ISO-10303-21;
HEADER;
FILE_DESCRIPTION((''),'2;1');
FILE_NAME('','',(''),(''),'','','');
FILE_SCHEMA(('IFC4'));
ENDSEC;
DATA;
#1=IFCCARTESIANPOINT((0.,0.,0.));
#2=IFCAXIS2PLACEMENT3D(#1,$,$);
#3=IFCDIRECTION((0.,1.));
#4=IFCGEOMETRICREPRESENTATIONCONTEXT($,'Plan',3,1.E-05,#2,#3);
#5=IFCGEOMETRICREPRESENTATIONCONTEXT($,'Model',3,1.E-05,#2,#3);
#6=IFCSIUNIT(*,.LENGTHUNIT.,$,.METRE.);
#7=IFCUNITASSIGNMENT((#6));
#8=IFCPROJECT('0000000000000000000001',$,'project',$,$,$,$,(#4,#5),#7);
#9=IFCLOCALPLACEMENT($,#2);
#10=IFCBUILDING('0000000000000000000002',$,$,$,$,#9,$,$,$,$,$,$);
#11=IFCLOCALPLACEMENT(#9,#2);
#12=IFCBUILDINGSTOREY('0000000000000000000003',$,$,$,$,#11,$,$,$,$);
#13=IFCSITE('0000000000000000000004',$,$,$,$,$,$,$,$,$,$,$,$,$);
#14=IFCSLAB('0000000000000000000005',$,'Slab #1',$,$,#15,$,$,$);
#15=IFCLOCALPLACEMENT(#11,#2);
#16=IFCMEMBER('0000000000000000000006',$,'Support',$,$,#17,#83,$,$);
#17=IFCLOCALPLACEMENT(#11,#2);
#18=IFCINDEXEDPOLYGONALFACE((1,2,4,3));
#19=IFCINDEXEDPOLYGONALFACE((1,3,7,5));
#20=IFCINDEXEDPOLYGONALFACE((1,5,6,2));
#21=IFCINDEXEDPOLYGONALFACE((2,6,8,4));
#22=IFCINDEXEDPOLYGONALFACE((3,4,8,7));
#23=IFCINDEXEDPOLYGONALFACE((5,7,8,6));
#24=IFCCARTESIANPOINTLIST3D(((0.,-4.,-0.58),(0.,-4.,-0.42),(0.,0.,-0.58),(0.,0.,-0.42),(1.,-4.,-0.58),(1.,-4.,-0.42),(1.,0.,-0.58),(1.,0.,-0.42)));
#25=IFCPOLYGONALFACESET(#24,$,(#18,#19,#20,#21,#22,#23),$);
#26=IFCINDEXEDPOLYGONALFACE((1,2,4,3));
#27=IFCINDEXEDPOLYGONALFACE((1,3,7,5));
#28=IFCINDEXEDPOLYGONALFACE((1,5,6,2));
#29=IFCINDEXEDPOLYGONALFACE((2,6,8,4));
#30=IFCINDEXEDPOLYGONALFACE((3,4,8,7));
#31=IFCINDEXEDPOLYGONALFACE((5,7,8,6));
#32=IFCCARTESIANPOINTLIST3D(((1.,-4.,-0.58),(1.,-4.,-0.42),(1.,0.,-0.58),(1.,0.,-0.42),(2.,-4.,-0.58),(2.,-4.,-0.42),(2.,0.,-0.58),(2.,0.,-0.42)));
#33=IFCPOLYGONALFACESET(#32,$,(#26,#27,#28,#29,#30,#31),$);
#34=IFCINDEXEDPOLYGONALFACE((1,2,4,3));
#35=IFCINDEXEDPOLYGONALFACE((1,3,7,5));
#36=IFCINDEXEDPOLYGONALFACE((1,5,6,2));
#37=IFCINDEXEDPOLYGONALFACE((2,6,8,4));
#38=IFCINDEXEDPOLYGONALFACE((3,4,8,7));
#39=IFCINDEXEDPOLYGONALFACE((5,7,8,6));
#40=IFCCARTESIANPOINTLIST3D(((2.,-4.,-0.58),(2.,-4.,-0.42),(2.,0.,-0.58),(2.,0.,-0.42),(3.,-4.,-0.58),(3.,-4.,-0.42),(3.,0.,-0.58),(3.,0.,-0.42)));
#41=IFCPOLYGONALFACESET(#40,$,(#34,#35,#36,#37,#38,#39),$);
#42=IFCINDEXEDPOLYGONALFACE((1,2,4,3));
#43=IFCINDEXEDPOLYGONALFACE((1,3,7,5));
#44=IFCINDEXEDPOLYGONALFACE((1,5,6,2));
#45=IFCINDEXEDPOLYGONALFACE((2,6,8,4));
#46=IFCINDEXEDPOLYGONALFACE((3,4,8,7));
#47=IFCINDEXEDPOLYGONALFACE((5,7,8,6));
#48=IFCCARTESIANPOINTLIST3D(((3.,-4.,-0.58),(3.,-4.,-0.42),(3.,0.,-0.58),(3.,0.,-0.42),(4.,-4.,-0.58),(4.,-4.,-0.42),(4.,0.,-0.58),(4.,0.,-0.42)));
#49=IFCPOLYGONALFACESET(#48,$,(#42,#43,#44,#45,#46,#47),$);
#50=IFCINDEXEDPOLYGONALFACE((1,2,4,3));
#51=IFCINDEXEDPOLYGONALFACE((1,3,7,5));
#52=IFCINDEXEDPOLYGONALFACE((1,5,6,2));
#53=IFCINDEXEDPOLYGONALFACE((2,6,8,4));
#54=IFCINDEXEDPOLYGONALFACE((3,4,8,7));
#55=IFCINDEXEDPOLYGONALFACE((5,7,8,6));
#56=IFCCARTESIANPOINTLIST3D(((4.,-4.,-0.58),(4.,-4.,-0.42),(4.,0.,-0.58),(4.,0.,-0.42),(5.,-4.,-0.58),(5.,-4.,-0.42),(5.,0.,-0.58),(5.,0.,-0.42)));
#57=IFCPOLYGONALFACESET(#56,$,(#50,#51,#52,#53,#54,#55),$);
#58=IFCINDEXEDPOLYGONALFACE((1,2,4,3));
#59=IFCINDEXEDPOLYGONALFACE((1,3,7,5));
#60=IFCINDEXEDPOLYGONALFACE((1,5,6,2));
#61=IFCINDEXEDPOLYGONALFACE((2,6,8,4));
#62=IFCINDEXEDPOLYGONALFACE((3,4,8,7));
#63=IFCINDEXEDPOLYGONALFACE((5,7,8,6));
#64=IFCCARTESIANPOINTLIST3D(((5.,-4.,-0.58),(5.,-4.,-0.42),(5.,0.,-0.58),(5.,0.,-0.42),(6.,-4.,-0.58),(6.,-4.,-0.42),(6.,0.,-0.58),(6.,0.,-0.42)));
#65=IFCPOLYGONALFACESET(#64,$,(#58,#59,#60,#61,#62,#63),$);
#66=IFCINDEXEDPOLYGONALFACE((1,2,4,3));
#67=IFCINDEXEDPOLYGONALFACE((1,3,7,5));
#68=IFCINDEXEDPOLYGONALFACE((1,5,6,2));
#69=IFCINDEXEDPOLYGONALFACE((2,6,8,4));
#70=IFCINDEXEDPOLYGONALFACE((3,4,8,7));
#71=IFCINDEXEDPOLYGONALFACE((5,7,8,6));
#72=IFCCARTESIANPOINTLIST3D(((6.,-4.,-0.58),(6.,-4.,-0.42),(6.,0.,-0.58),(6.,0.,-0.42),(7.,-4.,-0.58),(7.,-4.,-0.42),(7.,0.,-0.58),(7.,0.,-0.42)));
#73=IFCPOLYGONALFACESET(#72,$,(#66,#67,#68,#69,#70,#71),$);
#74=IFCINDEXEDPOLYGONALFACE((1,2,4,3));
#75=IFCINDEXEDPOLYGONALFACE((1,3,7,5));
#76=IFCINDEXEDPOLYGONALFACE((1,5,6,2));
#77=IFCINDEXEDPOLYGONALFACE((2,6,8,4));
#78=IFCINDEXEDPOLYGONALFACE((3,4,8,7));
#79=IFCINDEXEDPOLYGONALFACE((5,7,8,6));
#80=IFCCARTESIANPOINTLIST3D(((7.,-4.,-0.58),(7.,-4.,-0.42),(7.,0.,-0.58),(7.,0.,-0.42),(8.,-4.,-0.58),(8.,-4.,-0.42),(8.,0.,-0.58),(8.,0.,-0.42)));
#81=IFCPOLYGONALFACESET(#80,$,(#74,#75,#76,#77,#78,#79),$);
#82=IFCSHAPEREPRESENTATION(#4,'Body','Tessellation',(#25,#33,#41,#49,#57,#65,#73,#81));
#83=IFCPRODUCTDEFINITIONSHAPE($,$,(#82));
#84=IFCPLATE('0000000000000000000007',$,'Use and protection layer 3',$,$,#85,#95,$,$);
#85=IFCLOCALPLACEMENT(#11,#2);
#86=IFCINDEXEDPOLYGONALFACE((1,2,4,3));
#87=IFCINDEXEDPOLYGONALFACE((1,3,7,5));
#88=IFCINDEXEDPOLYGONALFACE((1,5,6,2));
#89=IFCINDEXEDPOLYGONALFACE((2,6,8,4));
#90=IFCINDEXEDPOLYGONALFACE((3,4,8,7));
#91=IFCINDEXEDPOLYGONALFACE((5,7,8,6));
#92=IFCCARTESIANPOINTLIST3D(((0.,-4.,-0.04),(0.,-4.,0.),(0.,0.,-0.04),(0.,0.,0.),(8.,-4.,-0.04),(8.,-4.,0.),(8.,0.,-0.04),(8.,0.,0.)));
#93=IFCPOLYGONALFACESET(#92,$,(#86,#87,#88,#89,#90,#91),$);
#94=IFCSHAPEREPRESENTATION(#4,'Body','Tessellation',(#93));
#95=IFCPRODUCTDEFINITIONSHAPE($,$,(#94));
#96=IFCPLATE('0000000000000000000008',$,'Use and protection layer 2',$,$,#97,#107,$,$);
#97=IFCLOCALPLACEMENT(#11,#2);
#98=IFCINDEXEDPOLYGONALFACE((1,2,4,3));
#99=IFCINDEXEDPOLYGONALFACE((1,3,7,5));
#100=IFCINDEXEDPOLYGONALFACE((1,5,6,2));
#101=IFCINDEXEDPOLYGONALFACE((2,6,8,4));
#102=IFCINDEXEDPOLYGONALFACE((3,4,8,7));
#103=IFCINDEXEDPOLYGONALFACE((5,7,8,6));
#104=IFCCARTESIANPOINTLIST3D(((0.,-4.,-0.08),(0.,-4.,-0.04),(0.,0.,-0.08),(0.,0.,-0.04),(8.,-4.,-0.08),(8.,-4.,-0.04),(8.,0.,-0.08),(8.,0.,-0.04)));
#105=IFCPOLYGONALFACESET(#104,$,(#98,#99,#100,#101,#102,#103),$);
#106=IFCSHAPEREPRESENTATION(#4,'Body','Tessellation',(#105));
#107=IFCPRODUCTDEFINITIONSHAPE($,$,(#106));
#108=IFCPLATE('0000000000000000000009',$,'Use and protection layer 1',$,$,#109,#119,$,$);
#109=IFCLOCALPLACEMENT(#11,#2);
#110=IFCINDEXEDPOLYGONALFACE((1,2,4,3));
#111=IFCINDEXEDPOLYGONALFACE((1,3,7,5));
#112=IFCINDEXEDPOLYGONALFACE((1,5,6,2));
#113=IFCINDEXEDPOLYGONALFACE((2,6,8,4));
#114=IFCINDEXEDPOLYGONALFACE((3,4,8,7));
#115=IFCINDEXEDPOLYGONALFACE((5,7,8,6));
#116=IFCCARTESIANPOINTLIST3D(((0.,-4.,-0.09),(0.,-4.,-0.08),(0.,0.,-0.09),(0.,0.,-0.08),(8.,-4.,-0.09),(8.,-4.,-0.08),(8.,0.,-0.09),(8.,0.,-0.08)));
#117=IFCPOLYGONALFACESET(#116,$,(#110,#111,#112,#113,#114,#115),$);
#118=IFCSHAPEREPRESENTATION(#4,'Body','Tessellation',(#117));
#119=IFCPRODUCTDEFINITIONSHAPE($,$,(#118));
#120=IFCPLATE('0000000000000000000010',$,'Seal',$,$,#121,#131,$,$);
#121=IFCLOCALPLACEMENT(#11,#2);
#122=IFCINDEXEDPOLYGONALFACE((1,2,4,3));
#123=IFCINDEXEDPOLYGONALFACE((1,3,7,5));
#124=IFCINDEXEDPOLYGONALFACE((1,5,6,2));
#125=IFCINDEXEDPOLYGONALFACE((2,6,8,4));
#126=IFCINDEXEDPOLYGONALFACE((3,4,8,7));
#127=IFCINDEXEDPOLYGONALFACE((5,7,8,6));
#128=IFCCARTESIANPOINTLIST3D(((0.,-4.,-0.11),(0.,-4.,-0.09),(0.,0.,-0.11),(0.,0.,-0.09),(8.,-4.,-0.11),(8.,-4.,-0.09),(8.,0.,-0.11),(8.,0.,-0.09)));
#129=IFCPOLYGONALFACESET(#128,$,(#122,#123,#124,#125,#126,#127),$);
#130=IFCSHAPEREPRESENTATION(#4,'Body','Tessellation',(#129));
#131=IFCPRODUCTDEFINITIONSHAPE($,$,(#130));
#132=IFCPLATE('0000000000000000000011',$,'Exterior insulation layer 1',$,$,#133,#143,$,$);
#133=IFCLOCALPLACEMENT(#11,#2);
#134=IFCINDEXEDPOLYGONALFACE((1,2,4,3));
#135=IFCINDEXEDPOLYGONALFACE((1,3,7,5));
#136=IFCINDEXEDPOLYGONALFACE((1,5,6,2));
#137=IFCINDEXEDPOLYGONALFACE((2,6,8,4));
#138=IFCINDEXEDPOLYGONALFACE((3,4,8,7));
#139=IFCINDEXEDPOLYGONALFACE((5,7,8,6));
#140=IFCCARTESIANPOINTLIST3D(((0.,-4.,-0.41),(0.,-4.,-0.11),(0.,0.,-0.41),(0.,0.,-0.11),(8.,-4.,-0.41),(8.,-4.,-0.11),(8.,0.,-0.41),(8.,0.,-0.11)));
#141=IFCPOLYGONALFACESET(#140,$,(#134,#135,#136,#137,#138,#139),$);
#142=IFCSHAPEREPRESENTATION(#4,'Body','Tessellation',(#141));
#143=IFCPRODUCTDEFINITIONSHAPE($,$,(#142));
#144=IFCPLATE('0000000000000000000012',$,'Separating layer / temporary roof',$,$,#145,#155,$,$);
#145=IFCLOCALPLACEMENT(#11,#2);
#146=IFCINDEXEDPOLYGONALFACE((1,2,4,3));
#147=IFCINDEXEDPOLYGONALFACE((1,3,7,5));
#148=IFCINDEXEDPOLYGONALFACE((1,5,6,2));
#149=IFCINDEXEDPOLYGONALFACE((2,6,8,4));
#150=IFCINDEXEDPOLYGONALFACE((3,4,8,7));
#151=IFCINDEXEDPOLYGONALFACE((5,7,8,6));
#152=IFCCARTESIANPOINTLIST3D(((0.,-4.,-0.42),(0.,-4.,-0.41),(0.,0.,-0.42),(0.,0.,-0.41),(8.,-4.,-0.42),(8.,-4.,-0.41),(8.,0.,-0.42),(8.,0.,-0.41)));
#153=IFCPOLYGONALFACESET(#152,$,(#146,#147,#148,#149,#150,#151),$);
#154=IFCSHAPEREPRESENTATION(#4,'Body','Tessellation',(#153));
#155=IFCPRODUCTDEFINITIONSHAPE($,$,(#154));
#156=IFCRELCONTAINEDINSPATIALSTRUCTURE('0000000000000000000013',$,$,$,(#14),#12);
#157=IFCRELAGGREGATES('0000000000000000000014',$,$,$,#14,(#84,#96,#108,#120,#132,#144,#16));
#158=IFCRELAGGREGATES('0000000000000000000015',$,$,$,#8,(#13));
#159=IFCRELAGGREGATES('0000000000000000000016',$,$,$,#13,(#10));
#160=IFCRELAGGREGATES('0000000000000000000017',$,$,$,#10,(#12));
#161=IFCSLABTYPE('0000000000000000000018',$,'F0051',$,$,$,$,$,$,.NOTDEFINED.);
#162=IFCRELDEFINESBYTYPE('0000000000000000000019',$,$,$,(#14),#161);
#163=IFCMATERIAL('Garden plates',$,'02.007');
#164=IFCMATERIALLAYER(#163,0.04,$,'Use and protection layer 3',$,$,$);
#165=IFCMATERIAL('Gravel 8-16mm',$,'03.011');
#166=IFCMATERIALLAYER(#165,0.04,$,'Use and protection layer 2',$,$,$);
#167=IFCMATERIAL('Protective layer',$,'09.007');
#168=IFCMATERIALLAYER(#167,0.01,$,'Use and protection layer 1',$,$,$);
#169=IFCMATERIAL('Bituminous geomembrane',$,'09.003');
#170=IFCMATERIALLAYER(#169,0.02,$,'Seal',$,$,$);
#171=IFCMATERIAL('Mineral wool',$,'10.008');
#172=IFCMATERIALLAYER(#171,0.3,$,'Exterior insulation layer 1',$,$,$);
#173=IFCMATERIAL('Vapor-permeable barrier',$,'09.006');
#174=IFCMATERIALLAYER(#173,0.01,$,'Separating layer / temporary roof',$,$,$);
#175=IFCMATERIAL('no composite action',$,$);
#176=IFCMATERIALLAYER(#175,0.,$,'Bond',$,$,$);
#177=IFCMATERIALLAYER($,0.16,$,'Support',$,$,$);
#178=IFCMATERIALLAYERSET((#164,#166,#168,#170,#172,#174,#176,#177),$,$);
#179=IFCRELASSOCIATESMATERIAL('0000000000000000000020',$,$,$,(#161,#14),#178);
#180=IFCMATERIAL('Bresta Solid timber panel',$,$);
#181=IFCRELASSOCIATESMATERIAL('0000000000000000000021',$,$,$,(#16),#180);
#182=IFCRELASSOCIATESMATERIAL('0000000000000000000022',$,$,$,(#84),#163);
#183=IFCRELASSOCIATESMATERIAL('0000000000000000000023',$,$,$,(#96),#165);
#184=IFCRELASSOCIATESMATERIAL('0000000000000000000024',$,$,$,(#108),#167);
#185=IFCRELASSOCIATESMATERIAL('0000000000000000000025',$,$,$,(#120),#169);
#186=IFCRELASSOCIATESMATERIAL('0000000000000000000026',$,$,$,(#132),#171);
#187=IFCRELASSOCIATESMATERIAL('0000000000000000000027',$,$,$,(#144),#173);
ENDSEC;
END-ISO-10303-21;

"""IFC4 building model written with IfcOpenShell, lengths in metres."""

from ifc_helpers import new_model, si_unit, direction, frame, frame_2d, origin, origin_with_axes, place, context, project, spatial, rectangle, extrude, material, layer, layer_set, type_object, element, aggregate, save


model = new_model("IFC4")

# Units and contexts
plan_context = context("Plan", 3, precision=1e-05, world=origin(), true_north=direction((0.0, 1.0)))
model_context = context("Model", 3, precision=1e-05, world=origin(), true_north=direction((0.0, 1.0)))
ifc_project = project(units=[si_unit("LENGTHUNIT", "METRE")], contexts=[plan_context, model_context])

# Site, building, storey
site = spatial("IfcSite", under=ifc_project)
building_placement = place(None, origin())
building = spatial("IfcBuilding", under=site, at=building_placement)
storey_placement = place(building_placement, origin())
storey = spatial("IfcBuildingStorey", under=building, at=storey_placement)

# Slab, member, plates
ifc_material_1 = material(Name="Garden plates", Category="02.007")
ifc_layer_1 = layer(ifc_material_1, 0.04, Name="Use and protection layer 3")
ifc_material_2 = material(Name="Gravel 8-16mm", Category="03.011")
ifc_layer_2 = layer(ifc_material_2, 0.04, Name="Use and protection layer 2")
ifc_material_3 = material(Name="Protective layer", Category="09.007")
ifc_layer_3 = layer(ifc_material_3, 0.01, Name="Use and protection layer 1")
ifc_material_4 = material(Name="Bituminous geomembrane", Category="09.003")
ifc_layer_4 = layer(ifc_material_4, 0.02, Name="Seal")
ifc_material_5 = material(Name="Mineral wool", Category="10.008")
ifc_layer_5 = layer(ifc_material_5, 0.3, Name="Exterior insulation layer 1")
ifc_material_6 = material(Name="Vapor-permeable barrier", Category="09.006")
ifc_layer_6 = layer(ifc_material_6, 0.01, Name="Separating layer / temporary roof")
ifc_material_7 = material(Name="no composite action")
ifc_layer_7 = layer(ifc_material_7, 0.0, Name="Bond")
ifc_layer_8 = layer(None, 0.16, Name="Support")
ifc_layer_set = layer_set([ifc_layer_1, ifc_layer_2, ifc_layer_3, ifc_layer_4, ifc_layer_5, ifc_layer_6, ifc_layer_7, ifc_layer_8])
slab_type = type_object("IfcSlabType", Name="F0051", PredefinedType="NOTDEFINED", material=ifc_layer_set)
slab_placement = place(None, frame((0.0, 0.0, 0.0), z_axis=(0.0, 0.0, -1.0), x_axis=(1.0, 0.0, 0.0)))
slab = element("IfcSlab", 1, at=slab_placement, inside=storey, type_object=slab_type, material=ifc_layer_set, Name="Slab #1")
ifc_material_8 = material(Name="Bresta Solid timber panel")
member_placement = place(slab_placement, origin())
member = element("IfcMember", 2, at=member_placement, material=ifc_material_8, Name="Support", context=plan_context, shape_type="SweptSolid", body=[
    extrude(rectangle(XDim=1.0, YDim=0.16, at=frame_2d((0.5, 0.08), x_axis=(1.0, 0.0))), frame((0.0, 4.0, 0.42), z_axis=(0.0, -1.0, 0.0), x_axis=(1.0, 0.0, 0.0)), (0.0, 0.0, 1.0), 4.0),
    extrude(rectangle(XDim=1.0, YDim=0.16, at=frame_2d((0.5, 0.08), x_axis=(1.0, 0.0))), frame((1.0, 4.0, 0.42), z_axis=(0.0, -1.0, 0.0), x_axis=(1.0, 0.0, 0.0)), (0.0, 0.0, 1.0), 4.0),
    extrude(rectangle(XDim=1.0, YDim=0.16, at=frame_2d((0.5, 0.08), x_axis=(1.0, 0.0))), frame((2.0, 4.0, 0.42), z_axis=(0.0, -1.0, 0.0), x_axis=(1.0, 0.0, 0.0)), (0.0, 0.0, 1.0), 4.0),
    extrude(rectangle(XDim=1.0, YDim=0.16, at=frame_2d((0.5, 0.08), x_axis=(1.0, 0.0))), frame((3.0, 4.0, 0.42), z_axis=(0.0, -1.0, 0.0), x_axis=(1.0, 0.0, 0.0)), (0.0, 0.0, 1.0), 4.0),
    extrude(rectangle(XDim=1.0, YDim=0.16, at=frame_2d((0.5, 0.08), x_axis=(1.0, 0.0))), frame((4.0, 4.0, 0.42), z_axis=(0.0, -1.0, 0.0), x_axis=(1.0, 0.0, 0.0)), (0.0, 0.0, 1.0), 4.0),
    extrude(rectangle(XDim=1.0, YDim=0.16, at=frame_2d((0.5, 0.08), x_axis=(1.0, 0.0))), frame((5.0, 4.0, 0.42), z_axis=(0.0, -1.0, 0.0), x_axis=(1.0, 0.0, 0.0)), (0.0, 0.0, 1.0), 4.0),
    extrude(rectangle(XDim=1.0, YDim=0.16, at=frame_2d((0.5, 0.08), x_axis=(1.0, 0.0))), frame((6.0, 4.0, 0.42), z_axis=(0.0, -1.0, 0.0), x_axis=(1.0, 0.0, 0.0)), (0.0, 0.0, 1.0), 4.0),
    extrude(rectangle(XDim=1.0, YDim=0.16, at=frame_2d((0.5, 0.08), x_axis=(1.0, 0.0))), frame((7.0, 4.0, 0.42), z_axis=(0.0, -1.0, 0.0), x_axis=(1.0, 0.0, 0.0)), (0.0, 0.0, 1.0), 4.0),
])
plate_1_placement = place(slab_placement, origin())
plate_1 = element("IfcPlate", 3, at=plate_1_placement, material=ifc_material_1, Name="Use and protection layer 3", context=plan_context, shape_type="SweptSolid", body=[
    extrude(rectangle(XDim=8.0, YDim=4.0, at=frame_2d((4.0, 2.0), x_axis=(1.0, 0.0))), origin_with_axes(), (0.0, 0.0, 1.0), 0.04),
])
plate_2_placement = place(slab_placement, origin())
plate_2 = element("IfcPlate", 4, at=plate_2_placement, material=ifc_material_2, Name="Use and protection layer 2", context=plan_context, shape_type="SweptSolid", body=[
    extrude(rectangle(XDim=8.0, YDim=4.0, at=frame_2d((4.0, 2.0), x_axis=(1.0, 0.0))), frame((0.0, 0.0, 0.04), z_axis=(0.0, 0.0, 1.0), x_axis=(1.0, 0.0, 0.0)), (0.0, 0.0, 1.0), 0.04),
])
plate_3_placement = place(slab_placement, origin())
plate_3 = element("IfcPlate", 5, at=plate_3_placement, material=ifc_material_3, Name="Use and protection layer 1", context=plan_context, shape_type="SweptSolid", body=[
    extrude(rectangle(XDim=8.0, YDim=4.0, at=frame_2d((4.0, 2.0), x_axis=(1.0, 0.0))), frame((0.0, 0.0, 0.08), z_axis=(0.0, 0.0, 1.0), x_axis=(1.0, 0.0, 0.0)), (0.0, 0.0, 1.0), 0.01),
])
plate_4_placement = place(slab_placement, origin())
plate_4 = element("IfcPlate", 6, at=plate_4_placement, material=ifc_material_4, Name="Seal", context=plan_context, shape_type="SweptSolid", body=[
    extrude(rectangle(XDim=8.0, YDim=4.0, at=frame_2d((4.0, 2.0), x_axis=(1.0, 0.0))), frame((0.0, 0.0, 0.09), z_axis=(0.0, 0.0, 1.0), x_axis=(1.0, 0.0, 0.0)), (0.0, 0.0, 1.0), 0.02),
])
plate_5_placement = place(slab_placement, origin())
plate_5 = element("IfcPlate", 7, at=plate_5_placement, material=ifc_material_5, Name="Exterior insulation layer 1", context=plan_context, shape_type="SweptSolid", body=[
    extrude(rectangle(XDim=8.0, YDim=4.0, at=frame_2d((4.0, 2.0), x_axis=(1.0, 0.0))), frame((0.0, 0.0, 0.11), z_axis=(0.0, 0.0, 1.0), x_axis=(1.0, 0.0, 0.0)), (0.0, 0.0, 1.0), 0.3),
])
plate_6_placement = place(slab_placement, origin())
plate_6 = element("IfcPlate", 8, at=plate_6_placement, material=ifc_material_6, Name="Separating layer / temporary roof", context=plan_context, shape_type="SweptSolid", body=[
    extrude(rectangle(XDim=8.0, YDim=4.0, at=frame_2d((4.0, 2.0), x_axis=(1.0, 0.0))), frame((0.0, 0.0, 0.41), z_axis=(0.0, 0.0, 1.0), x_axis=(1.0, 0.0, 0.0)), (0.0, 0.0, 1.0), 0.01),
])
aggregate(slab, [plate_1, plate_2, plate_3, plate_4, plate_5, plate_6, member])

save(model, "model.ifc")
